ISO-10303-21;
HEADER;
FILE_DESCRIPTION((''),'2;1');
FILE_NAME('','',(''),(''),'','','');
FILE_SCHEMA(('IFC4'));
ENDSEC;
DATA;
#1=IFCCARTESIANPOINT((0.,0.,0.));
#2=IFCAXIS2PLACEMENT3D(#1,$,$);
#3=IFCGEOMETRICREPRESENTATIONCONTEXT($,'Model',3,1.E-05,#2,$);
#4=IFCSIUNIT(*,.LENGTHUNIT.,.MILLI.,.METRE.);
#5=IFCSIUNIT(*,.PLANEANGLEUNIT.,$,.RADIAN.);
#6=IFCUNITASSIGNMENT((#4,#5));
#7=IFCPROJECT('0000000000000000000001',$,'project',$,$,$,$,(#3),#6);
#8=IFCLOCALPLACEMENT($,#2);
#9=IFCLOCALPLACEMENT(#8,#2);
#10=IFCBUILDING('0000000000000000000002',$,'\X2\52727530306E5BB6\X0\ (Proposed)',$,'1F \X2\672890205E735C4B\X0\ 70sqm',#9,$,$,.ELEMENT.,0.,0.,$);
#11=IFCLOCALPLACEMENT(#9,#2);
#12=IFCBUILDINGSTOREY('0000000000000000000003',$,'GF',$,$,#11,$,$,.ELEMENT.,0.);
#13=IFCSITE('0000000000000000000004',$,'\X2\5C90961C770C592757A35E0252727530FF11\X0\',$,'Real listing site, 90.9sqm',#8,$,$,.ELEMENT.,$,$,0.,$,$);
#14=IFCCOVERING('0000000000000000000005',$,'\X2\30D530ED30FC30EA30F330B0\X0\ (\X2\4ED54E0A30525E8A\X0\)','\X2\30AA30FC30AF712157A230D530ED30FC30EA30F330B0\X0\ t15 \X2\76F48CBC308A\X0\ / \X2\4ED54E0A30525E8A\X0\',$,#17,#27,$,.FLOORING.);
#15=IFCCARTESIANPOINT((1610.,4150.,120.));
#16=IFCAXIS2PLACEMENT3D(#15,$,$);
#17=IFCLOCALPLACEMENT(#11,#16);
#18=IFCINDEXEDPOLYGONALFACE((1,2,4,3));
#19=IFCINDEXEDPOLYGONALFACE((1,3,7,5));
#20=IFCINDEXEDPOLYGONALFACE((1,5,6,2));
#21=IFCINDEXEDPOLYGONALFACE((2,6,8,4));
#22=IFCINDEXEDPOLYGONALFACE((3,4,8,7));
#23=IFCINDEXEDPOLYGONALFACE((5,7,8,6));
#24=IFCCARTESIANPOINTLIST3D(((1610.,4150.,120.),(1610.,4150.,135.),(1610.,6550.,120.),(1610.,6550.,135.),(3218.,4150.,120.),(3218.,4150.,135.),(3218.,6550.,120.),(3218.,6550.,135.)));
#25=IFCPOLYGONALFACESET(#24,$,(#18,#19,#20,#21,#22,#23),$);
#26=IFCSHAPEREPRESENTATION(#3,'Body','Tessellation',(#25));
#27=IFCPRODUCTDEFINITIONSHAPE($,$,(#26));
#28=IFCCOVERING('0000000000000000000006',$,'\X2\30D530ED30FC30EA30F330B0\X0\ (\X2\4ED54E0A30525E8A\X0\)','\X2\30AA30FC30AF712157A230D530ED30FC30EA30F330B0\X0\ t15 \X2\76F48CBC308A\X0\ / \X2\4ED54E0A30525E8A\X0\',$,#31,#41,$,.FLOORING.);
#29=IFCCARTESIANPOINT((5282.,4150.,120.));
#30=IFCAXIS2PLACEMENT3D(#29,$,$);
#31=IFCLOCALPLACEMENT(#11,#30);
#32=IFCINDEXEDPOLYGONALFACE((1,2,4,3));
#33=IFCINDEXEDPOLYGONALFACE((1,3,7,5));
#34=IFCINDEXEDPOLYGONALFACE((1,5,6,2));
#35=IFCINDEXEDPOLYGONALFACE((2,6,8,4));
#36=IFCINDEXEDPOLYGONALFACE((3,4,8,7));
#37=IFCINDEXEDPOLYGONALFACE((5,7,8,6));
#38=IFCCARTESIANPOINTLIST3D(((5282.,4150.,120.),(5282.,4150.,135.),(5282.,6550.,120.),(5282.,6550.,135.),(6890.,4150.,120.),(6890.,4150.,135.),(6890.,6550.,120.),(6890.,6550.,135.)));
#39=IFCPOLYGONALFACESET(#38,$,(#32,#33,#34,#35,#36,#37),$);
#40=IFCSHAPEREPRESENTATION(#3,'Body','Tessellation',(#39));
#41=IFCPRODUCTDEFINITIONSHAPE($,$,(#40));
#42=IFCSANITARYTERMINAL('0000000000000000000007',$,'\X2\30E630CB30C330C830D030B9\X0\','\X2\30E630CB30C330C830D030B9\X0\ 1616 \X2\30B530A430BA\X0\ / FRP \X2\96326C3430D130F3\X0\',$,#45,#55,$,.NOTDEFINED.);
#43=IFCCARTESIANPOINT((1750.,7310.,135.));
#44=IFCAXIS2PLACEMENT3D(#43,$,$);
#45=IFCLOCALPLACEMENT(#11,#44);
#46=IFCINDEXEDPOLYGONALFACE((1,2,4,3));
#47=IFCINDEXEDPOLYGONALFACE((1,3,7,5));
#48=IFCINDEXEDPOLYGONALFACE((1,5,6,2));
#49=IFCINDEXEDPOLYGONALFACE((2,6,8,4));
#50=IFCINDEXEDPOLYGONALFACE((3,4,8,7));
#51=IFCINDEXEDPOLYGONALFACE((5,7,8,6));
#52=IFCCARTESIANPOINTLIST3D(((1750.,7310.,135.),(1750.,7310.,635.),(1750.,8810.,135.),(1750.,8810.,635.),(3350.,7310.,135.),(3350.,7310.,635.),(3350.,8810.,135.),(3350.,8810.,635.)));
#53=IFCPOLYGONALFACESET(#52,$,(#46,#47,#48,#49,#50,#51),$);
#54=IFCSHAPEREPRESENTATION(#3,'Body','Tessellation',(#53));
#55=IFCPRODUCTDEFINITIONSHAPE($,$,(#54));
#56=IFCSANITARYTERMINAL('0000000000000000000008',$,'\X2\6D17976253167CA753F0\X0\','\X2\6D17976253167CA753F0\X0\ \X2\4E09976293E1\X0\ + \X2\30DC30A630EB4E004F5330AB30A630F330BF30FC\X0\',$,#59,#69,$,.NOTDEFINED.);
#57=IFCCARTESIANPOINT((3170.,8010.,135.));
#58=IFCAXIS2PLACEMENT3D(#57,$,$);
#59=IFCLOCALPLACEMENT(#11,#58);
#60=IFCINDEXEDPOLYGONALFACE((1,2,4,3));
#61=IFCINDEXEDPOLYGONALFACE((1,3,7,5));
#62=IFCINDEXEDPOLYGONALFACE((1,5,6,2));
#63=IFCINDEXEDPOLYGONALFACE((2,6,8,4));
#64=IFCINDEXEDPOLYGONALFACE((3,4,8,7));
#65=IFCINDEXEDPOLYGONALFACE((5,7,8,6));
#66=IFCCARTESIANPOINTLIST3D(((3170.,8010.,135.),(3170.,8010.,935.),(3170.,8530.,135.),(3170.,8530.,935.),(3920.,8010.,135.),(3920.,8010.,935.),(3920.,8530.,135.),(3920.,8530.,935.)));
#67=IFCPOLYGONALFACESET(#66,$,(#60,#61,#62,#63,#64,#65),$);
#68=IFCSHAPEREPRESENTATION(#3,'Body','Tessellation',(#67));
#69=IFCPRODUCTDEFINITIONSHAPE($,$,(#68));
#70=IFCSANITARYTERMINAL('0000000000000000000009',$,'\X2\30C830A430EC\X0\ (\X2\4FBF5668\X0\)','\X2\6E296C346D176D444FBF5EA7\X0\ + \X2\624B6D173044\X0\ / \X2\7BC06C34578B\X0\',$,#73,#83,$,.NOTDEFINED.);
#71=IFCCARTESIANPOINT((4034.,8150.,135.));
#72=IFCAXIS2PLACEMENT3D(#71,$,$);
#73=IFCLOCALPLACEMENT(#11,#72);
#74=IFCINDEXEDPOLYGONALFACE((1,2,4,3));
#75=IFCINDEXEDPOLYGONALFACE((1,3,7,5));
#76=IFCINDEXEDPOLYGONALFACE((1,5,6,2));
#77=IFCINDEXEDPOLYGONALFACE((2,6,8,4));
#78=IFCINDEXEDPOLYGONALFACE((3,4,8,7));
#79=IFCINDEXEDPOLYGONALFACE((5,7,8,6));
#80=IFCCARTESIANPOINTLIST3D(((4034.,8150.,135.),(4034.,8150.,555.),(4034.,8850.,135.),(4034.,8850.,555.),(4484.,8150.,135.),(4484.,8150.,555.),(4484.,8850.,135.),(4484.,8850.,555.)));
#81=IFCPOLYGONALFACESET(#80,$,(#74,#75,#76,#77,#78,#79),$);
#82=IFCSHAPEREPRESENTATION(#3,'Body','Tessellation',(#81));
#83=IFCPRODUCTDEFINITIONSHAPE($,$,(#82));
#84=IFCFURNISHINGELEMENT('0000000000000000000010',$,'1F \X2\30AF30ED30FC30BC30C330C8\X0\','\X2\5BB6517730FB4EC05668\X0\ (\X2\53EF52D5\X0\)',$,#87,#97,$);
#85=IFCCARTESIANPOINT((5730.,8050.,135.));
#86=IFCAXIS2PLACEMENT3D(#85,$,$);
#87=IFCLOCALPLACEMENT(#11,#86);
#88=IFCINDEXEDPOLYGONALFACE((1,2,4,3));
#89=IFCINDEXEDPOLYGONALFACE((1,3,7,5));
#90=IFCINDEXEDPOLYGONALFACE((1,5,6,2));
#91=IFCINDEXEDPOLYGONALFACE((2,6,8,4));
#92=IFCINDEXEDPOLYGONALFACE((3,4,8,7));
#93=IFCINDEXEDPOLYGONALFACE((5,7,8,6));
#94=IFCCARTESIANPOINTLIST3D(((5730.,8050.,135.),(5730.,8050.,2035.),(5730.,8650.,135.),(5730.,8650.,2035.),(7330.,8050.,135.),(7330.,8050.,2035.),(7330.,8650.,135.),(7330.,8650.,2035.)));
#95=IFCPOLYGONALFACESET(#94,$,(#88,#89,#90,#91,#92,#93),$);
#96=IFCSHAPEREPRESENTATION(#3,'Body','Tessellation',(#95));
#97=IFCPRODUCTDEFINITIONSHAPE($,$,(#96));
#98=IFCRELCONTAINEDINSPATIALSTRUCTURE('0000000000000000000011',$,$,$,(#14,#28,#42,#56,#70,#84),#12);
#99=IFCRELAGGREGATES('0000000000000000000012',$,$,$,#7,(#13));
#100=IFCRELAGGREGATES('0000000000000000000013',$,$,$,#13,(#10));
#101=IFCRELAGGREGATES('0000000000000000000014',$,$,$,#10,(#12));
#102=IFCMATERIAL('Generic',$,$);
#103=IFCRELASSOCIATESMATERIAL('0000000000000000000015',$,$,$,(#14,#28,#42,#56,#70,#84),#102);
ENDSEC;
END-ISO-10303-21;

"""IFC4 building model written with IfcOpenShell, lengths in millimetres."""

from ifc_helpers import new_model, si_unit, frame, frame_2d, origin, place, context, project, spatial, rectangle, extrude, material, element, save


model = new_model("IFC4")

# Units and contexts
model_context = context("Model", 3, precision=1e-05, world=origin())
ifc_project = project(units=[si_unit("LENGTHUNIT", "METRE", prefix="MILLI"), si_unit("PLANEANGLEUNIT", "RADIAN")], contexts=[model_context])

# Site, building, storey
site_placement = place(None, origin())
site = spatial("IfcSite", under=ifc_project, at=site_placement, Name="岐阜県大垣市割田１", ObjectType="Real listing site, 90.9sqm", CompositionType="ELEMENT", RefElevation=0.0)
building_placement = place(site_placement, origin())
building = spatial("IfcBuilding", under=site, at=building_placement, Name="割田の家 (Proposed)", ObjectType="1F 木造平屋 70sqm", CompositionType="ELEMENT", ElevationOfRefHeight=0.0, ElevationOfTerrain=0.0)
storey_placement = place(building_placement, origin())
storey = spatial("IfcBuildingStorey", under=building, at=storey_placement, Name="GF", CompositionType="ELEMENT", Elevation=0.0)

# Coverings
ifc_material_1 = material(Name="Generic")
covering_1_placement = place(storey_placement, frame((1610.0, 4150.0, 120.0)))
element("IfcCovering", 1, at=covering_1_placement, inside=storey, material=ifc_material_1, Name="フローリング (仕上げ床)", Description="オーク無垢フローリング t15 直貼り / 仕上げ床", PredefinedType="FLOORING", context=model_context, shape_type="SweptSolid", body=[
    extrude(rectangle(XDim=1608.0, YDim=2400.0, at=frame_2d((804.0, 1200.0))), frame((1610.0, 4150.0, 120.0)), (0.0, 0.0, 1.0), 15.0),
])
covering_2_placement = place(storey_placement, frame((5282.0, 4150.0, 120.0)))
element("IfcCovering", 2, at=covering_2_placement, inside=storey, material=ifc_material_1, Name="フローリング (仕上げ床)", Description="オーク無垢フローリング t15 直貼り / 仕上げ床", PredefinedType="FLOORING", context=model_context, shape_type="SweptSolid", body=[
    extrude(rectangle(XDim=1608.0, YDim=2400.0, at=frame_2d((804.0, 1200.0))), frame((5282.0, 4150.0, 120.0)), (0.0, 0.0, 1.0), 15.0),
])

# Sanitary terminals
sanitary_terminal_1_placement = place(storey_placement, frame((1750.0, 7310.0, 135.0)))
element("IfcSanitaryTerminal", 3, at=sanitary_terminal_1_placement, inside=storey, material=ifc_material_1, Name="ユニットバス", Description="ユニットバス 1616 サイズ / FRP 防水パン", PredefinedType="NOTDEFINED", context=model_context, shape_type="SweptSolid", body=[
    extrude(rectangle(XDim=1600.0, YDim=1500.0, at=frame_2d((800.0, 750.0))), frame((1750.0, 7310.0, 135.0)), (0.0, 0.0, 1.0), 500.0),
])
sanitary_terminal_2_placement = place(storey_placement, frame((3170.0, 8010.0, 135.0)))
element("IfcSanitaryTerminal", 4, at=sanitary_terminal_2_placement, inside=storey, material=ifc_material_1, Name="洗面化粧台", Description="洗面化粧台 三面鏡 + ボウル一体カウンター", PredefinedType="NOTDEFINED", context=model_context, shape_type="SweptSolid", body=[
    extrude(rectangle(XDim=750.0, YDim=520.0, at=frame_2d((375.0, 260.0))), frame((3170.0, 8010.0, 135.0)), (0.0, 0.0, 1.0), 800.0),
])
sanitary_terminal_3_placement = place(storey_placement, frame((4034.0, 8150.0, 135.0)))
element("IfcSanitaryTerminal", 5, at=sanitary_terminal_3_placement, inside=storey, material=ifc_material_1, Name="トイレ (便器)", Description="温水洗浄便座 + 手洗い / 節水型", PredefinedType="NOTDEFINED", context=model_context, shape_type="SweptSolid", body=[
    extrude(rectangle(XDim=450.0, YDim=700.0, at=frame_2d((225.0, 350.0))), frame((4034.0, 8150.0, 135.0)), (0.0, 0.0, 1.0), 420.0),
])

# Furnishing element
furnishing_placement = place(storey_placement, frame((5730.0, 8050.0, 135.0)))
element("IfcFurnishingElement", 6, at=furnishing_placement, inside=storey, material=ifc_material_1, Name="1F クローゼット", Description="家具・什器 (可動)", context=model_context, shape_type="SweptSolid", body=[
    extrude(rectangle(XDim=1600.0, YDim=600.0, at=frame_2d((800.0, 300.0))), frame((5730.0, 8050.0, 135.0)), (0.0, 0.0, 1.0), 1900.0),
])

save(model, "model.ifc")
